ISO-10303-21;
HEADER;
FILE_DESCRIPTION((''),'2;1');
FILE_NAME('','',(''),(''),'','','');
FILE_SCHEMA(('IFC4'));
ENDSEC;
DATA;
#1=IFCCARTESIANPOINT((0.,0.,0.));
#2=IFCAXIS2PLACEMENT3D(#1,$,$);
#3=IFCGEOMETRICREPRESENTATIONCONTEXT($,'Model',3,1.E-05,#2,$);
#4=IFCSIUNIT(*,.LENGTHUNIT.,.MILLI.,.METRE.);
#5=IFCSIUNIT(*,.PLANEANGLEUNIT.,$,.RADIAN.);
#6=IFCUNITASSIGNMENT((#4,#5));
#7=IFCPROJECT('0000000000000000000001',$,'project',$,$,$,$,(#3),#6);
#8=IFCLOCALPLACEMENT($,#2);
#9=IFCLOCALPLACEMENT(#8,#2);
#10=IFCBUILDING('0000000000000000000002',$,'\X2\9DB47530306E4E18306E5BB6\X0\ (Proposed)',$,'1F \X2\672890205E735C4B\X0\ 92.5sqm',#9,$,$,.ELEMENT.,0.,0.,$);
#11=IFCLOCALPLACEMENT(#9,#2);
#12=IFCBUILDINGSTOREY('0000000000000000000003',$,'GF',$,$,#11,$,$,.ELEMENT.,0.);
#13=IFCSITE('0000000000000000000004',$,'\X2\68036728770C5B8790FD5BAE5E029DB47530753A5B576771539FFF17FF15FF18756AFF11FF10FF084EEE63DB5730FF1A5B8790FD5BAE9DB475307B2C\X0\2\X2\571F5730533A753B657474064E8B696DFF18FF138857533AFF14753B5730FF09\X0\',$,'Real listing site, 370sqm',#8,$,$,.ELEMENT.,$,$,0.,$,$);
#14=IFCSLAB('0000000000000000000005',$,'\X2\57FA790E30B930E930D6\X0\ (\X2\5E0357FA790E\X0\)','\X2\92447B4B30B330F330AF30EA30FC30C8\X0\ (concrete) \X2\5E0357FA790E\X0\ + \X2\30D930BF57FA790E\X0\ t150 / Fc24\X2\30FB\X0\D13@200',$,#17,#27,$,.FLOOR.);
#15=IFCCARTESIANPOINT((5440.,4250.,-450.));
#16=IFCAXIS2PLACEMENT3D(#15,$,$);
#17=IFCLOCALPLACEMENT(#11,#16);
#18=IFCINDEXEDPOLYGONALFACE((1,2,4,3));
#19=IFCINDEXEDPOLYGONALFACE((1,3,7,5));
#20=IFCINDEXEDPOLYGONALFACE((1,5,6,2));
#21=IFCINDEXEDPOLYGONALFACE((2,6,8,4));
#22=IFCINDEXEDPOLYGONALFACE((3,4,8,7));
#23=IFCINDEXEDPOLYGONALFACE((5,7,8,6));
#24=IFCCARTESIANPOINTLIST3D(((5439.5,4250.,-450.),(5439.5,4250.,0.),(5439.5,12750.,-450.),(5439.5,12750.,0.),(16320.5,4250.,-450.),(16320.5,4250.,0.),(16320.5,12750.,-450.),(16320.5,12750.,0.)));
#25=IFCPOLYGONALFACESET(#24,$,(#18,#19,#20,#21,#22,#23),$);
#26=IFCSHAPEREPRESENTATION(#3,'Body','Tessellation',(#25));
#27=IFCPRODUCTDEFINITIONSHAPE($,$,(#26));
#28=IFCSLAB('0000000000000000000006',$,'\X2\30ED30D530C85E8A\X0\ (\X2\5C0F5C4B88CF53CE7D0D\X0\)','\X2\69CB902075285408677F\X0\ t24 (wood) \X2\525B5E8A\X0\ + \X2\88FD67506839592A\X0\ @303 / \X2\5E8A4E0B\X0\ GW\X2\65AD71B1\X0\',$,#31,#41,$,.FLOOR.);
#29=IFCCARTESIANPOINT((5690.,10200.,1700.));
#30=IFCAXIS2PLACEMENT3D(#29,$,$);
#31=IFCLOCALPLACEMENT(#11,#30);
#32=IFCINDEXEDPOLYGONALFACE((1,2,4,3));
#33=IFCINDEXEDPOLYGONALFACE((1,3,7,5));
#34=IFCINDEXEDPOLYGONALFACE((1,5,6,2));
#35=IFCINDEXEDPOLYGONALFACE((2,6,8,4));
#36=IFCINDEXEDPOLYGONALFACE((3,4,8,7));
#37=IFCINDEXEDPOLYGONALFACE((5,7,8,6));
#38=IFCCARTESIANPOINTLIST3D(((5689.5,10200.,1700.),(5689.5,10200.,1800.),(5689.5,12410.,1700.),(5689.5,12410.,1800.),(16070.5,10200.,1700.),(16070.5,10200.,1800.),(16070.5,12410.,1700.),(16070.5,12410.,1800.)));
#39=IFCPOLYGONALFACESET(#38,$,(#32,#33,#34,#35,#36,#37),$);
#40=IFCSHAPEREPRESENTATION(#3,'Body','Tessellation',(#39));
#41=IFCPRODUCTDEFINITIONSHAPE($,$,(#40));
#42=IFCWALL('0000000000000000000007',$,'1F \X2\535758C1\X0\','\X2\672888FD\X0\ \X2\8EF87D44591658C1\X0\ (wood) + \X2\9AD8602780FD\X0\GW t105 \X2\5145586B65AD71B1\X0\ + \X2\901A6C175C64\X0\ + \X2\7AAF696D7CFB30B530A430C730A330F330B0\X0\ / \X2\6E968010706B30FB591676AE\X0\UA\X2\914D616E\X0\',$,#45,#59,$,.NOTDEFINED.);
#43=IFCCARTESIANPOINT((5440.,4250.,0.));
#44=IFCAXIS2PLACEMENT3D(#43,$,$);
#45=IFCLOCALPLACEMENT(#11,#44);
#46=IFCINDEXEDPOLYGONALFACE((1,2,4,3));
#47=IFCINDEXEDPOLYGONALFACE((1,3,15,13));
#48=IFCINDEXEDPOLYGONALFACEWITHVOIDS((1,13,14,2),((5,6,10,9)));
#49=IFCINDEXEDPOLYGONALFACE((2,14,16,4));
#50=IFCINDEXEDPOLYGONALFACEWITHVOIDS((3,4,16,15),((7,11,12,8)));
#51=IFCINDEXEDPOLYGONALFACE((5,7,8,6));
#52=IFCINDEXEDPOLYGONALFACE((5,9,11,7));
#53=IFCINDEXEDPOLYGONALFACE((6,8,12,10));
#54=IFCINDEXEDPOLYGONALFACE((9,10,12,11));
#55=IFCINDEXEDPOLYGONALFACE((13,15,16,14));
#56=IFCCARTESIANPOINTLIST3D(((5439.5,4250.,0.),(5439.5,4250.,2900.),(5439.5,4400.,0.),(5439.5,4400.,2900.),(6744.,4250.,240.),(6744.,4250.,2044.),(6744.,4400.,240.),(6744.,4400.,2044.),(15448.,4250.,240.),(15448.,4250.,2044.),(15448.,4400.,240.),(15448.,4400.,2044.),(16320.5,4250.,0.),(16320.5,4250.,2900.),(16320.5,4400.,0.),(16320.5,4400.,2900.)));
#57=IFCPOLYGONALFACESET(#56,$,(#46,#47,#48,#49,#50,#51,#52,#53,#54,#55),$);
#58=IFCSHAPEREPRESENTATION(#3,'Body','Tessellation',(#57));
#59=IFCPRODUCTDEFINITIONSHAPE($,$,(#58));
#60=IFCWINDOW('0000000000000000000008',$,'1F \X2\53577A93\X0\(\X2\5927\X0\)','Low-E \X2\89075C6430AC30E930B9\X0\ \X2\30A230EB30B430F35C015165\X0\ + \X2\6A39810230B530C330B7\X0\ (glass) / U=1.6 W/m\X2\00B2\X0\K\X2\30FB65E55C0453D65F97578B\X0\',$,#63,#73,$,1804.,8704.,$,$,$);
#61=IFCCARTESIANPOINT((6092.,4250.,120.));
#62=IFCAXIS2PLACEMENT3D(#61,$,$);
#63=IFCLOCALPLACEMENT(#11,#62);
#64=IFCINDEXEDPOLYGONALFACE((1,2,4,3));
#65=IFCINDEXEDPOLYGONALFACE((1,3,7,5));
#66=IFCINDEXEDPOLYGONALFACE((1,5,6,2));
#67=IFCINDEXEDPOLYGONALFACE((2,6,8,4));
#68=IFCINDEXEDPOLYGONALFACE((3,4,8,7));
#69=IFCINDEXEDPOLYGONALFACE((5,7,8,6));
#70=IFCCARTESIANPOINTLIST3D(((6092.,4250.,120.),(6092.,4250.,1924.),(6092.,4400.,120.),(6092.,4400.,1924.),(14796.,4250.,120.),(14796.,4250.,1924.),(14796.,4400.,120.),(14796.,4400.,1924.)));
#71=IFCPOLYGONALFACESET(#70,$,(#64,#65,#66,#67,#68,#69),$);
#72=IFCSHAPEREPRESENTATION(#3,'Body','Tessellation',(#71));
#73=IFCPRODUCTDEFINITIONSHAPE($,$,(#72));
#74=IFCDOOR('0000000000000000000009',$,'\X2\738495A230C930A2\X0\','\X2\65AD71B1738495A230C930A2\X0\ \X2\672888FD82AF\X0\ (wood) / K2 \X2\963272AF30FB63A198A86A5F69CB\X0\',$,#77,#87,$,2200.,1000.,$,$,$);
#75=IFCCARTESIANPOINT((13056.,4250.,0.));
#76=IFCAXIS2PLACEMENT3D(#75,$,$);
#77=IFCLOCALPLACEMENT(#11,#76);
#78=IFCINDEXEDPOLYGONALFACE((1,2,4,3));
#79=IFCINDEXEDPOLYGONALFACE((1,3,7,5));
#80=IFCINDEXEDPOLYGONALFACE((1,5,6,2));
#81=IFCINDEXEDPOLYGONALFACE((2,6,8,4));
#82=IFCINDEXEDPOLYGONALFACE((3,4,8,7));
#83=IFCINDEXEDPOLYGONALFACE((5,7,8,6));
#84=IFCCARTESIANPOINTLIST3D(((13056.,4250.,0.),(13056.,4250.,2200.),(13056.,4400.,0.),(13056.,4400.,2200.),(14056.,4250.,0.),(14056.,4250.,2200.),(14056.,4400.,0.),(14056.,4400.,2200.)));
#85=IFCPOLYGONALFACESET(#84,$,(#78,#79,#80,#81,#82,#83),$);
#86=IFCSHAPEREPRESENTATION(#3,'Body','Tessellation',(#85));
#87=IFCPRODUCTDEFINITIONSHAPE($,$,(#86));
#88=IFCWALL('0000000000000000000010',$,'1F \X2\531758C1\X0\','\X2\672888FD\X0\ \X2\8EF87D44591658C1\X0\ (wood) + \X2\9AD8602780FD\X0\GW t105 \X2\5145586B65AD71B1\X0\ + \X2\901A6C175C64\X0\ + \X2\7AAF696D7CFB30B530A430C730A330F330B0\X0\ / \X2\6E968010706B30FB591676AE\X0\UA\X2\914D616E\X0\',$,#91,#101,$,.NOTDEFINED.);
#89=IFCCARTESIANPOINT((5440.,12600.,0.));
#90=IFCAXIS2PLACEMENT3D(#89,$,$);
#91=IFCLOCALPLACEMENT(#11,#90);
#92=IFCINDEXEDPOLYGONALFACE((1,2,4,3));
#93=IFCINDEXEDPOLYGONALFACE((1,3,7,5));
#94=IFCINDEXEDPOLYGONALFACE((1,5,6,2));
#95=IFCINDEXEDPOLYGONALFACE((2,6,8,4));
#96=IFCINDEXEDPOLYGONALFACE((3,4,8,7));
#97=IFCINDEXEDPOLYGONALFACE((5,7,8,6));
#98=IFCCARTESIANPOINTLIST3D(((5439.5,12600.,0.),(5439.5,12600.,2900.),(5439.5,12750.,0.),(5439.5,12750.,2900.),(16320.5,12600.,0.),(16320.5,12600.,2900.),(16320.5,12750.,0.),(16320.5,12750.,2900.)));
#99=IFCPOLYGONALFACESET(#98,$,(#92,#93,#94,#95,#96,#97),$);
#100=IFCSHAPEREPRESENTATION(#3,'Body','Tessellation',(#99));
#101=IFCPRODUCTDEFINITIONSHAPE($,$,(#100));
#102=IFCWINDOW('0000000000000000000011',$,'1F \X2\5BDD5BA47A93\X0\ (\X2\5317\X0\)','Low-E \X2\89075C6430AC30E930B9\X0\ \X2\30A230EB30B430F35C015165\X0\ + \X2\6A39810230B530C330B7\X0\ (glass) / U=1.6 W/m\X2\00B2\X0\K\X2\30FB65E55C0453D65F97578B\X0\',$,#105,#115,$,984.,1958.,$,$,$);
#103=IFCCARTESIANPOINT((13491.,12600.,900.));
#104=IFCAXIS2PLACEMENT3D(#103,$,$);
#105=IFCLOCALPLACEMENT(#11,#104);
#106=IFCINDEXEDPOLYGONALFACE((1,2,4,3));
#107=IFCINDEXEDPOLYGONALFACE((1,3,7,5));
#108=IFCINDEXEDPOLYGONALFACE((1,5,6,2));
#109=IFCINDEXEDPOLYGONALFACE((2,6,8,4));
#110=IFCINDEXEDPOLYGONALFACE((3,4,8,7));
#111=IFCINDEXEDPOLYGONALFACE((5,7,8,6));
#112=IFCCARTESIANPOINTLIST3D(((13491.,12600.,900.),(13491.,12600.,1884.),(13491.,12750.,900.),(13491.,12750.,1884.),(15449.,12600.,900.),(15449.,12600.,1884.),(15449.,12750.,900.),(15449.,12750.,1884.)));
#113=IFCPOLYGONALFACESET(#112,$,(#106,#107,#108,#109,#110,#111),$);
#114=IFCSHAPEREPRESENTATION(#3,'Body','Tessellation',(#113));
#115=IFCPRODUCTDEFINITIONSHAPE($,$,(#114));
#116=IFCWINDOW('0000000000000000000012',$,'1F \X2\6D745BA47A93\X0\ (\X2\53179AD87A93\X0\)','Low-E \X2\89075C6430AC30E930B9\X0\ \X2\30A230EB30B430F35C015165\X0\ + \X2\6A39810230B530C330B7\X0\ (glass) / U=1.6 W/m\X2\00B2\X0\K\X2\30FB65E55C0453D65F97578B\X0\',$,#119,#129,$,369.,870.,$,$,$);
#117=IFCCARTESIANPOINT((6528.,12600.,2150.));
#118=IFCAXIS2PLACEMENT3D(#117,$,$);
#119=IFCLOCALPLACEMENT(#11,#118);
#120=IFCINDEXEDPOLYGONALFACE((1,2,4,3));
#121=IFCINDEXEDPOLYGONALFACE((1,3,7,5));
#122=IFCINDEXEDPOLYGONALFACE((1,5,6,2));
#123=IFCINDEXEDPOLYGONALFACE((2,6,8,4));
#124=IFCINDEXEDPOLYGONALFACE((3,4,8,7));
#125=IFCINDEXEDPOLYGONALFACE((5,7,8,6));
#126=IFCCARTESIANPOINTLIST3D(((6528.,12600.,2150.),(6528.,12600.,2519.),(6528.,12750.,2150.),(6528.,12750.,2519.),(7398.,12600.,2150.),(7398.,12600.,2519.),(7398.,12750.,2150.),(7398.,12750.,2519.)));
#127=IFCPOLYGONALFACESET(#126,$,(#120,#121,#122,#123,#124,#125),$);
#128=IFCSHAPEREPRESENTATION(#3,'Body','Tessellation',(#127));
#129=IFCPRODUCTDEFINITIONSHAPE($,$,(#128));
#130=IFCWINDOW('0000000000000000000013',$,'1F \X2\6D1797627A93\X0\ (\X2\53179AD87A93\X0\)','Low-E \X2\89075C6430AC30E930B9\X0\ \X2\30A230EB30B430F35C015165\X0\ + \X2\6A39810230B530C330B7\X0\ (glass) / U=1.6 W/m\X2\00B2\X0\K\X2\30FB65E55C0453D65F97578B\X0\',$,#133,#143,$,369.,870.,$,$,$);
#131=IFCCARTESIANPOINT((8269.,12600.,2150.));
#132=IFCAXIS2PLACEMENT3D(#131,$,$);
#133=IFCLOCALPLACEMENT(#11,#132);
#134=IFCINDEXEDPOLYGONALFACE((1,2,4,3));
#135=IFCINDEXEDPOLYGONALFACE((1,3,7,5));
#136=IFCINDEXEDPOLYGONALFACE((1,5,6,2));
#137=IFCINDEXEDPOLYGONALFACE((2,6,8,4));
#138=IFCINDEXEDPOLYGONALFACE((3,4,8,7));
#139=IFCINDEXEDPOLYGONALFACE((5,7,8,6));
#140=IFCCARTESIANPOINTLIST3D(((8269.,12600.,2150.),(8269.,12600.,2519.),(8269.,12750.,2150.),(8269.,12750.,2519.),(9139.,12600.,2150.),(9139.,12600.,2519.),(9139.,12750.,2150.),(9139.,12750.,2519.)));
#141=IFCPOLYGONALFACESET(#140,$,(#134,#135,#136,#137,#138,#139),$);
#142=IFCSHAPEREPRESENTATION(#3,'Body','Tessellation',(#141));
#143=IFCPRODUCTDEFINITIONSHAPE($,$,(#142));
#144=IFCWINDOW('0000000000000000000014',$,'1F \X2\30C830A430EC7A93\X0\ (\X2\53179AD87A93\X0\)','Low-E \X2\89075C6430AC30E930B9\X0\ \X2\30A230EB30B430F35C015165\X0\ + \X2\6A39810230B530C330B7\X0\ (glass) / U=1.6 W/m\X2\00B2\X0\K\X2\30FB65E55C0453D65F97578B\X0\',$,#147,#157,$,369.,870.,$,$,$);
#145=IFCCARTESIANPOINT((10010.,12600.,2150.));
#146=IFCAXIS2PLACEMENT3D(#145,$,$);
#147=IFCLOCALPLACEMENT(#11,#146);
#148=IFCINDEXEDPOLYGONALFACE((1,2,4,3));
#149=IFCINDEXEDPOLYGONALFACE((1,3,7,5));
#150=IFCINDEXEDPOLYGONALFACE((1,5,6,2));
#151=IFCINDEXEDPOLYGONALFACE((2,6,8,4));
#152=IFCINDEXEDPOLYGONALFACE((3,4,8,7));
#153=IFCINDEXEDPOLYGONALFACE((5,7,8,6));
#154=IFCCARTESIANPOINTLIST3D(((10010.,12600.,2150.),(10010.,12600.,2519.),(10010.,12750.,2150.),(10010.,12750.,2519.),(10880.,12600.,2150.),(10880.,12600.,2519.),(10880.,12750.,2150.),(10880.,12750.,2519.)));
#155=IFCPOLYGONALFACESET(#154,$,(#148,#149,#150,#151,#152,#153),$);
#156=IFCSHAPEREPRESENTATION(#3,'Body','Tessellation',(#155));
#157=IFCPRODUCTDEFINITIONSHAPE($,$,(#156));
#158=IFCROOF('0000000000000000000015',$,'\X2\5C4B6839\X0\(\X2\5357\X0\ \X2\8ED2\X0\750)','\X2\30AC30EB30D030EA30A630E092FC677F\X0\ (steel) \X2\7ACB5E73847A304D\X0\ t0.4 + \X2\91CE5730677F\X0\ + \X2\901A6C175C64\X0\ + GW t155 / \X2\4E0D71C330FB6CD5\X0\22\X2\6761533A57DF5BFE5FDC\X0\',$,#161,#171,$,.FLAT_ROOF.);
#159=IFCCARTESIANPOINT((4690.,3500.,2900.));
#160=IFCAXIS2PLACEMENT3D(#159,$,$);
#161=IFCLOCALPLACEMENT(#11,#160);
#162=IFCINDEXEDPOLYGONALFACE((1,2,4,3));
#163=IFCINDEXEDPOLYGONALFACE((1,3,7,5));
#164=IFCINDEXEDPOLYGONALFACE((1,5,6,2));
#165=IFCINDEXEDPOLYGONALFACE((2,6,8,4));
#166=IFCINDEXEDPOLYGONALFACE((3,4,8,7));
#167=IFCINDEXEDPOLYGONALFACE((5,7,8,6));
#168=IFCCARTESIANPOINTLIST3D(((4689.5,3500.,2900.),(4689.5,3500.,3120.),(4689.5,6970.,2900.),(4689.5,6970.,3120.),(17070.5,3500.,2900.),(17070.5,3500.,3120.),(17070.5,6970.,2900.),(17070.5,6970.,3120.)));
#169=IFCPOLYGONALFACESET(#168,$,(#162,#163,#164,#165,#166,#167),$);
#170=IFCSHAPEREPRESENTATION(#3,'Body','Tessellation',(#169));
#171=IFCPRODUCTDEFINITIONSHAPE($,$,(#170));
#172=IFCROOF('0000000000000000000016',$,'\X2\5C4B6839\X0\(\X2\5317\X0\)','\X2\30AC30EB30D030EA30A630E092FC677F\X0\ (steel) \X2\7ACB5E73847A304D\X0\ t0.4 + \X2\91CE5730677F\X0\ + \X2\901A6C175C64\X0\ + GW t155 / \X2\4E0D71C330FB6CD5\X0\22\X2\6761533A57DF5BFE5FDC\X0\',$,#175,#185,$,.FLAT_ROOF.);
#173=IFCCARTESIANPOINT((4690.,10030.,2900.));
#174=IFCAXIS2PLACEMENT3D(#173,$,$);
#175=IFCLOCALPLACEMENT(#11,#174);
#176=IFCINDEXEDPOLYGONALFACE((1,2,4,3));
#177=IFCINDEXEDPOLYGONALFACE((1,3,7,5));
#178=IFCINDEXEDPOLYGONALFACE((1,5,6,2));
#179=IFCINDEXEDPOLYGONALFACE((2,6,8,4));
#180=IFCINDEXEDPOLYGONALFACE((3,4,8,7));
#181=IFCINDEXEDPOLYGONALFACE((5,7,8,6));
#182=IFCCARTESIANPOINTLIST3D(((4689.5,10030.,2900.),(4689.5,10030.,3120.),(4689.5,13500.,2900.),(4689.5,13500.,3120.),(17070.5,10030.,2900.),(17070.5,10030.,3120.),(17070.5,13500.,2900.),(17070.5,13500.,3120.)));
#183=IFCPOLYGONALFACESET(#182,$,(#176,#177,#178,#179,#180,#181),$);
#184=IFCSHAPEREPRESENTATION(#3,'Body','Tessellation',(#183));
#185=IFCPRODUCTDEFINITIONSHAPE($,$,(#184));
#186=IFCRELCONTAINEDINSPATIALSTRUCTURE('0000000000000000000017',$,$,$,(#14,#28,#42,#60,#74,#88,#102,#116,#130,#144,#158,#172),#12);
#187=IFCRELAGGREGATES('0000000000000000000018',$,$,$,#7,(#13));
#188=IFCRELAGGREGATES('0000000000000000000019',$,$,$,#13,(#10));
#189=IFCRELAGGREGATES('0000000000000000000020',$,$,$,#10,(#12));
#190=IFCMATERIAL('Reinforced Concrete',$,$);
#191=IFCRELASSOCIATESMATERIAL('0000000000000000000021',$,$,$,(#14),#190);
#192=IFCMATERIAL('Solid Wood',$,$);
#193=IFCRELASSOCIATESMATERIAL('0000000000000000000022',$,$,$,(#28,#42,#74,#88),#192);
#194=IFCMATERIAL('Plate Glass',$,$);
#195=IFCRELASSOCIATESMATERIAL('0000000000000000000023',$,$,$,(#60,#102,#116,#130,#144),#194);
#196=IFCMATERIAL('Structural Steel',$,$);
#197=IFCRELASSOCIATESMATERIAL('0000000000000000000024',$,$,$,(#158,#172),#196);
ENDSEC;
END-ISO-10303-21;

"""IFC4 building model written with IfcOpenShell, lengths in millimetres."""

from ifc_helpers import new_model, si_unit, frame, frame_2d, origin, place, context, project, spatial, rectangle, extrude, material, element, fill, save


model = new_model("IFC4")

# Units and contexts
model_context = context("Model", 3, precision=1e-05, world=origin())
ifc_project = project(units=[si_unit("LENGTHUNIT", "METRE", prefix="MILLI"), si_unit("PLANEANGLEUNIT", "RADIAN")], contexts=[model_context])

# Site, building, storey
site_placement = place(None, origin())
site = spatial("IfcSite", under=ifc_project, at=site_placement, Name="栃木県宇都宮市鶴田町字東原７５８番１０（仮換地：宇都宮鶴田第2土地区画整理事業８３街区４画地）", ObjectType="Real listing site, 370sqm", CompositionType="ELEMENT", RefElevation=0.0)
building_placement = place(site_placement, origin())
building = spatial("IfcBuilding", under=site, at=building_placement, Name="鶴田の丘の家 (Proposed)", ObjectType="1F 木造平屋 92.5sqm", CompositionType="ELEMENT", ElevationOfRefHeight=0.0, ElevationOfTerrain=0.0)
storey_placement = place(building_placement, origin())
storey = spatial("IfcBuildingStorey", under=building, at=storey_placement, Name="GF", CompositionType="ELEMENT", Elevation=0.0)

# Slabs
ifc_material_1 = material(Name="Reinforced Concrete")
slab_1_placement = place(storey_placement, frame((5440.0, 4250.0, -450.0)))
element("IfcSlab", 1, at=slab_1_placement, inside=storey, material=ifc_material_1, Name="基礎スラブ (布基礎)", Description="鉄筋コンクリート (concrete) 布基礎 + ベタ基礎 t150 / Fc24・D13@200", PredefinedType="FLOOR", context=model_context, shape_type="SweptSolid", body=[
    extrude(rectangle(XDim=10881.0, YDim=8500.0, at=frame_2d((5440.0, 4250.0))), frame((5440.0, 4250.0, -450.0)), (0.0, 0.0, 1.0), 450.0),
])
ifc_material_2 = material(Name="Solid Wood")
slab_2_placement = place(storey_placement, frame((5690.0, 10200.0, 1700.0)))
element("IfcSlab", 2, at=slab_2_placement, inside=storey, material=ifc_material_2, Name="ロフト床 (小屋裏収納)", Description="構造用合板 t24 (wood) 剛床 + 製材根太 @303 / 床下 GW断熱", PredefinedType="FLOOR", context=model_context, shape_type="SweptSolid", body=[
    extrude(rectangle(XDim=10381.0, YDim=2210.0, at=frame_2d((5190.0, 1105.0))), frame((5690.0, 10200.0, 1700.0)), (0.0, 0.0, 1.0), 100.0),
])

# Wall, openings, window, door
wall_1_placement = place(storey_placement, frame((5440.0, 4250.0, 0.0)))
wall_1 = element("IfcWall", 3, at=wall_1_placement, inside=storey, material=ifc_material_2, Name="1F 南壁", Description="木製 軸組外壁 (wood) + 高性能GW t105 充填断熱 + 通気層 + 窯業系サイディング / 準耐火・外皮UA配慮", PredefinedType="NOTDEFINED", context=model_context, shape_type="SweptSolid", body=[
    extrude(rectangle(XDim=10881.0, YDim=150.0, at=frame_2d((5440.0, 75.0))), frame((5440.0, 4250.0, 0.0)), (0.0, 0.0, 1.0), 2900.0),
])
opening_1_placement = place(storey_placement, frame((6092.0, 4250.0, 120.0)))
opening_1 = element("IfcOpeningElement", 4, at=opening_1_placement, cuts=wall_1, PredefinedType="NOTDEFINED", context=model_context, shape_type="SweptSolid", body=[
    extrude(rectangle(XDim=8704.0, YDim=150.0, at=frame_2d((4352.0, 75.0))), frame((6092.0, 4250.0, 120.0)), (0.0, 0.0, 1.0), 1804.0),
])
opening_2_placement = place(storey_placement, frame((13056.0, 4250.0, 0.0)))
opening_2 = element("IfcOpeningElement", 5, at=opening_2_placement, cuts=wall_1, PredefinedType="NOTDEFINED", context=model_context, shape_type="SweptSolid", body=[
    extrude(rectangle(XDim=1000.0, YDim=150.0, at=frame_2d((500.0, 75.0))), frame((13056.0, 4250.0, 0.0)), (0.0, 0.0, 1.0), 2200.0),
])
ifc_material_3 = material(Name="Plate Glass")
window_1_placement = place(storey_placement, frame((6092.0, 4250.0, 120.0)))
window_1 = element("IfcWindow", 6, at=window_1_placement, inside=storey, material=ifc_material_3, Name="1F 南窓(大)", Description="Low-E 複層ガラス アルゴン封入 + 樹脂サッシ (glass) / U=1.6 W/m²K・日射取得型", OverallHeight=1804.0, OverallWidth=8704.0, context=model_context, shape_type="SweptSolid", body=[
    extrude(rectangle(XDim=8704.0, YDim=150.0, at=frame_2d((4352.0, 75.0))), frame((6092.0, 4250.0, 120.0)), (0.0, 0.0, 1.0), 1804.0),
])
fill(opening_1, window_1)
door_1_placement = place(storey_placement, frame((13056.0, 4250.0, 0.0)))
door_1 = element("IfcDoor", 7, at=door_1_placement, inside=storey, material=ifc_material_2, Name="玄関ドア", Description="断熱玄関ドア 木製芯 (wood) / K2 防犯・採風機構", OverallHeight=2200.0, OverallWidth=1000.0, context=model_context, shape_type="SweptSolid", body=[
    extrude(rectangle(XDim=1000.0, YDim=150.0, at=frame_2d((500.0, 75.0))), frame((13056.0, 4250.0, 0.0)), (0.0, 0.0, 1.0), 2200.0),
])
fill(opening_2, door_1)

# Wall, openings, windows
wall_2_placement = place(storey_placement, frame((5440.0, 12600.0, 0.0)))
wall_2 = element("IfcWall", 8, at=wall_2_placement, inside=storey, material=ifc_material_2, Name="1F 北壁", Description="木製 軸組外壁 (wood) + 高性能GW t105 充填断熱 + 通気層 + 窯業系サイディング / 準耐火・外皮UA配慮", PredefinedType="NOTDEFINED", context=model_context, shape_type="SweptSolid", body=[
    extrude(rectangle(XDim=10881.0, YDim=150.0, at=frame_2d((5440.0, 75.0))), frame((5440.0, 12600.0, 0.0)), (0.0, 0.0, 1.0), 2900.0),
])
opening_3_placement = place(storey_placement, frame((13491.0, 12600.0, 900.0)))
opening_3 = element("IfcOpeningElement", 9, at=opening_3_placement, cuts=wall_2, PredefinedType="NOTDEFINED", context=model_context, shape_type="SweptSolid", body=[
    extrude(rectangle(XDim=1958.0, YDim=150.0, at=frame_2d((979.0, 75.0))), frame((13491.0, 12600.0, 900.0)), (0.0, 0.0, 1.0), 984.0),
])
opening_4_placement = place(storey_placement, frame((6528.0, 12600.0, 2150.0)))
opening_4 = element("IfcOpeningElement", 10, at=opening_4_placement, cuts=wall_2, PredefinedType="NOTDEFINED", context=model_context, shape_type="SweptSolid", body=[
    extrude(rectangle(XDim=870.0, YDim=150.0, at=frame_2d((435.0, 75.0))), frame((6528.0, 12600.0, 2150.0)), (0.0, 0.0, 1.0), 369.0),
])
opening_5_placement = place(storey_placement, frame((8269.0, 12600.0, 2150.0)))
opening_5 = element("IfcOpeningElement", 11, at=opening_5_placement, cuts=wall_2, PredefinedType="NOTDEFINED", context=model_context, shape_type="SweptSolid", body=[
    extrude(rectangle(XDim=870.0, YDim=150.0, at=frame_2d((435.0, 75.0))), frame((8269.0, 12600.0, 2150.0)), (0.0, 0.0, 1.0), 369.0),
])
opening_6_placement = place(storey_placement, frame((10010.0, 12600.0, 2150.0)))
opening_6 = element("IfcOpeningElement", 12, at=opening_6_placement, cuts=wall_2, PredefinedType="NOTDEFINED", context=model_context, shape_type="SweptSolid", body=[
    extrude(rectangle(XDim=870.0, YDim=150.0, at=frame_2d((435.0, 75.0))), frame((10010.0, 12600.0, 2150.0)), (0.0, 0.0, 1.0), 369.0),
])
window_2_placement = place(storey_placement, frame((13491.0, 12600.0, 900.0)))
window_2 = element("IfcWindow", 13, at=window_2_placement, inside=storey, material=ifc_material_3, Name="1F 寝室窓 (北)", Description="Low-E 複層ガラス アルゴン封入 + 樹脂サッシ (glass) / U=1.6 W/m²K・日射取得型", OverallHeight=984.0, OverallWidth=1958.0, context=model_context, shape_type="SweptSolid", body=[
    extrude(rectangle(XDim=1958.0, YDim=150.0, at=frame_2d((979.0, 75.0))), frame((13491.0, 12600.0, 900.0)), (0.0, 0.0, 1.0), 984.0),
])
fill(opening_3, window_2)
window_3_placement = place(storey_placement, frame((6528.0, 12600.0, 2150.0)))
window_3 = element("IfcWindow", 14, at=window_3_placement, inside=storey, material=ifc_material_3, Name="1F 浴室窓 (北高窓)", Description="Low-E 複層ガラス アルゴン封入 + 樹脂サッシ (glass) / U=1.6 W/m²K・日射取得型", OverallHeight=369.0, OverallWidth=870.0, context=model_context, shape_type="SweptSolid", body=[
    extrude(rectangle(XDim=870.0, YDim=150.0, at=frame_2d((435.0, 75.0))), frame((6528.0, 12600.0, 2150.0)), (0.0, 0.0, 1.0), 369.0),
])
fill(opening_4, window_3)
window_4_placement = place(storey_placement, frame((8269.0, 12600.0, 2150.0)))
window_4 = element("IfcWindow", 15, at=window_4_placement, inside=storey, material=ifc_material_3, Name="1F 洗面窓 (北高窓)", Description="Low-E 複層ガラス アルゴン封入 + 樹脂サッシ (glass) / U=1.6 W/m²K・日射取得型", OverallHeight=369.0, OverallWidth=870.0, context=model_context, shape_type="SweptSolid", body=[
    extrude(rectangle(XDim=870.0, YDim=150.0, at=frame_2d((435.0, 75.0))), frame((8269.0, 12600.0, 2150.0)), (0.0, 0.0, 1.0), 369.0),
])
fill(opening_5, window_4)
window_5_placement = place(storey_placement, frame((10010.0, 12600.0, 2150.0)))
window_5 = element("IfcWindow", 16, at=window_5_placement, inside=storey, material=ifc_material_3, Name="1F トイレ窓 (北高窓)", Description="Low-E 複層ガラス アルゴン封入 + 樹脂サッシ (glass) / U=1.6 W/m²K・日射取得型", OverallHeight=369.0, OverallWidth=870.0, context=model_context, shape_type="SweptSolid", body=[
    extrude(rectangle(XDim=870.0, YDim=150.0, at=frame_2d((435.0, 75.0))), frame((10010.0, 12600.0, 2150.0)), (0.0, 0.0, 1.0), 369.0),
])
fill(opening_6, window_5)

# Roofs
ifc_material_4 = material(Name="Structural Steel")
roof_1_placement = place(storey_placement, frame((4690.0, 3500.0, 2900.0)))
element("IfcRoof", 17, at=roof_1_placement, inside=storey, material=ifc_material_4, Name="屋根(南 軒750)", Description="ガルバリウム鋼板 (steel) 立平葺き t0.4 + 野地板 + 通気層 + GW t155 / 不燃・法22条区域対応", PredefinedType="FLAT_ROOF", context=model_context, shape_type="SweptSolid", body=[
    extrude(rectangle(XDim=12381.0, YDim=3470.0, at=frame_2d((6190.0, 1735.0))), frame((4690.0, 3500.0, 2900.0)), (0.0, 0.0, 1.0), 220.0),
])
roof_2_placement = place(storey_placement, frame((4690.0, 10030.0, 2900.0)))
element("IfcRoof", 18, at=roof_2_placement, inside=storey, material=ifc_material_4, Name="屋根(北)", Description="ガルバリウム鋼板 (steel) 立平葺き t0.4 + 野地板 + 通気層 + GW t155 / 不燃・法22条区域対応", PredefinedType="FLAT_ROOF", context=model_context, shape_type="SweptSolid", body=[
    extrude(rectangle(XDim=12381.0, YDim=3470.0, at=frame_2d((6190.0, 1735.0))), frame((4690.0, 10030.0, 2900.0)), (0.0, 0.0, 1.0), 220.0),
])

save(model, "model.ifc")
